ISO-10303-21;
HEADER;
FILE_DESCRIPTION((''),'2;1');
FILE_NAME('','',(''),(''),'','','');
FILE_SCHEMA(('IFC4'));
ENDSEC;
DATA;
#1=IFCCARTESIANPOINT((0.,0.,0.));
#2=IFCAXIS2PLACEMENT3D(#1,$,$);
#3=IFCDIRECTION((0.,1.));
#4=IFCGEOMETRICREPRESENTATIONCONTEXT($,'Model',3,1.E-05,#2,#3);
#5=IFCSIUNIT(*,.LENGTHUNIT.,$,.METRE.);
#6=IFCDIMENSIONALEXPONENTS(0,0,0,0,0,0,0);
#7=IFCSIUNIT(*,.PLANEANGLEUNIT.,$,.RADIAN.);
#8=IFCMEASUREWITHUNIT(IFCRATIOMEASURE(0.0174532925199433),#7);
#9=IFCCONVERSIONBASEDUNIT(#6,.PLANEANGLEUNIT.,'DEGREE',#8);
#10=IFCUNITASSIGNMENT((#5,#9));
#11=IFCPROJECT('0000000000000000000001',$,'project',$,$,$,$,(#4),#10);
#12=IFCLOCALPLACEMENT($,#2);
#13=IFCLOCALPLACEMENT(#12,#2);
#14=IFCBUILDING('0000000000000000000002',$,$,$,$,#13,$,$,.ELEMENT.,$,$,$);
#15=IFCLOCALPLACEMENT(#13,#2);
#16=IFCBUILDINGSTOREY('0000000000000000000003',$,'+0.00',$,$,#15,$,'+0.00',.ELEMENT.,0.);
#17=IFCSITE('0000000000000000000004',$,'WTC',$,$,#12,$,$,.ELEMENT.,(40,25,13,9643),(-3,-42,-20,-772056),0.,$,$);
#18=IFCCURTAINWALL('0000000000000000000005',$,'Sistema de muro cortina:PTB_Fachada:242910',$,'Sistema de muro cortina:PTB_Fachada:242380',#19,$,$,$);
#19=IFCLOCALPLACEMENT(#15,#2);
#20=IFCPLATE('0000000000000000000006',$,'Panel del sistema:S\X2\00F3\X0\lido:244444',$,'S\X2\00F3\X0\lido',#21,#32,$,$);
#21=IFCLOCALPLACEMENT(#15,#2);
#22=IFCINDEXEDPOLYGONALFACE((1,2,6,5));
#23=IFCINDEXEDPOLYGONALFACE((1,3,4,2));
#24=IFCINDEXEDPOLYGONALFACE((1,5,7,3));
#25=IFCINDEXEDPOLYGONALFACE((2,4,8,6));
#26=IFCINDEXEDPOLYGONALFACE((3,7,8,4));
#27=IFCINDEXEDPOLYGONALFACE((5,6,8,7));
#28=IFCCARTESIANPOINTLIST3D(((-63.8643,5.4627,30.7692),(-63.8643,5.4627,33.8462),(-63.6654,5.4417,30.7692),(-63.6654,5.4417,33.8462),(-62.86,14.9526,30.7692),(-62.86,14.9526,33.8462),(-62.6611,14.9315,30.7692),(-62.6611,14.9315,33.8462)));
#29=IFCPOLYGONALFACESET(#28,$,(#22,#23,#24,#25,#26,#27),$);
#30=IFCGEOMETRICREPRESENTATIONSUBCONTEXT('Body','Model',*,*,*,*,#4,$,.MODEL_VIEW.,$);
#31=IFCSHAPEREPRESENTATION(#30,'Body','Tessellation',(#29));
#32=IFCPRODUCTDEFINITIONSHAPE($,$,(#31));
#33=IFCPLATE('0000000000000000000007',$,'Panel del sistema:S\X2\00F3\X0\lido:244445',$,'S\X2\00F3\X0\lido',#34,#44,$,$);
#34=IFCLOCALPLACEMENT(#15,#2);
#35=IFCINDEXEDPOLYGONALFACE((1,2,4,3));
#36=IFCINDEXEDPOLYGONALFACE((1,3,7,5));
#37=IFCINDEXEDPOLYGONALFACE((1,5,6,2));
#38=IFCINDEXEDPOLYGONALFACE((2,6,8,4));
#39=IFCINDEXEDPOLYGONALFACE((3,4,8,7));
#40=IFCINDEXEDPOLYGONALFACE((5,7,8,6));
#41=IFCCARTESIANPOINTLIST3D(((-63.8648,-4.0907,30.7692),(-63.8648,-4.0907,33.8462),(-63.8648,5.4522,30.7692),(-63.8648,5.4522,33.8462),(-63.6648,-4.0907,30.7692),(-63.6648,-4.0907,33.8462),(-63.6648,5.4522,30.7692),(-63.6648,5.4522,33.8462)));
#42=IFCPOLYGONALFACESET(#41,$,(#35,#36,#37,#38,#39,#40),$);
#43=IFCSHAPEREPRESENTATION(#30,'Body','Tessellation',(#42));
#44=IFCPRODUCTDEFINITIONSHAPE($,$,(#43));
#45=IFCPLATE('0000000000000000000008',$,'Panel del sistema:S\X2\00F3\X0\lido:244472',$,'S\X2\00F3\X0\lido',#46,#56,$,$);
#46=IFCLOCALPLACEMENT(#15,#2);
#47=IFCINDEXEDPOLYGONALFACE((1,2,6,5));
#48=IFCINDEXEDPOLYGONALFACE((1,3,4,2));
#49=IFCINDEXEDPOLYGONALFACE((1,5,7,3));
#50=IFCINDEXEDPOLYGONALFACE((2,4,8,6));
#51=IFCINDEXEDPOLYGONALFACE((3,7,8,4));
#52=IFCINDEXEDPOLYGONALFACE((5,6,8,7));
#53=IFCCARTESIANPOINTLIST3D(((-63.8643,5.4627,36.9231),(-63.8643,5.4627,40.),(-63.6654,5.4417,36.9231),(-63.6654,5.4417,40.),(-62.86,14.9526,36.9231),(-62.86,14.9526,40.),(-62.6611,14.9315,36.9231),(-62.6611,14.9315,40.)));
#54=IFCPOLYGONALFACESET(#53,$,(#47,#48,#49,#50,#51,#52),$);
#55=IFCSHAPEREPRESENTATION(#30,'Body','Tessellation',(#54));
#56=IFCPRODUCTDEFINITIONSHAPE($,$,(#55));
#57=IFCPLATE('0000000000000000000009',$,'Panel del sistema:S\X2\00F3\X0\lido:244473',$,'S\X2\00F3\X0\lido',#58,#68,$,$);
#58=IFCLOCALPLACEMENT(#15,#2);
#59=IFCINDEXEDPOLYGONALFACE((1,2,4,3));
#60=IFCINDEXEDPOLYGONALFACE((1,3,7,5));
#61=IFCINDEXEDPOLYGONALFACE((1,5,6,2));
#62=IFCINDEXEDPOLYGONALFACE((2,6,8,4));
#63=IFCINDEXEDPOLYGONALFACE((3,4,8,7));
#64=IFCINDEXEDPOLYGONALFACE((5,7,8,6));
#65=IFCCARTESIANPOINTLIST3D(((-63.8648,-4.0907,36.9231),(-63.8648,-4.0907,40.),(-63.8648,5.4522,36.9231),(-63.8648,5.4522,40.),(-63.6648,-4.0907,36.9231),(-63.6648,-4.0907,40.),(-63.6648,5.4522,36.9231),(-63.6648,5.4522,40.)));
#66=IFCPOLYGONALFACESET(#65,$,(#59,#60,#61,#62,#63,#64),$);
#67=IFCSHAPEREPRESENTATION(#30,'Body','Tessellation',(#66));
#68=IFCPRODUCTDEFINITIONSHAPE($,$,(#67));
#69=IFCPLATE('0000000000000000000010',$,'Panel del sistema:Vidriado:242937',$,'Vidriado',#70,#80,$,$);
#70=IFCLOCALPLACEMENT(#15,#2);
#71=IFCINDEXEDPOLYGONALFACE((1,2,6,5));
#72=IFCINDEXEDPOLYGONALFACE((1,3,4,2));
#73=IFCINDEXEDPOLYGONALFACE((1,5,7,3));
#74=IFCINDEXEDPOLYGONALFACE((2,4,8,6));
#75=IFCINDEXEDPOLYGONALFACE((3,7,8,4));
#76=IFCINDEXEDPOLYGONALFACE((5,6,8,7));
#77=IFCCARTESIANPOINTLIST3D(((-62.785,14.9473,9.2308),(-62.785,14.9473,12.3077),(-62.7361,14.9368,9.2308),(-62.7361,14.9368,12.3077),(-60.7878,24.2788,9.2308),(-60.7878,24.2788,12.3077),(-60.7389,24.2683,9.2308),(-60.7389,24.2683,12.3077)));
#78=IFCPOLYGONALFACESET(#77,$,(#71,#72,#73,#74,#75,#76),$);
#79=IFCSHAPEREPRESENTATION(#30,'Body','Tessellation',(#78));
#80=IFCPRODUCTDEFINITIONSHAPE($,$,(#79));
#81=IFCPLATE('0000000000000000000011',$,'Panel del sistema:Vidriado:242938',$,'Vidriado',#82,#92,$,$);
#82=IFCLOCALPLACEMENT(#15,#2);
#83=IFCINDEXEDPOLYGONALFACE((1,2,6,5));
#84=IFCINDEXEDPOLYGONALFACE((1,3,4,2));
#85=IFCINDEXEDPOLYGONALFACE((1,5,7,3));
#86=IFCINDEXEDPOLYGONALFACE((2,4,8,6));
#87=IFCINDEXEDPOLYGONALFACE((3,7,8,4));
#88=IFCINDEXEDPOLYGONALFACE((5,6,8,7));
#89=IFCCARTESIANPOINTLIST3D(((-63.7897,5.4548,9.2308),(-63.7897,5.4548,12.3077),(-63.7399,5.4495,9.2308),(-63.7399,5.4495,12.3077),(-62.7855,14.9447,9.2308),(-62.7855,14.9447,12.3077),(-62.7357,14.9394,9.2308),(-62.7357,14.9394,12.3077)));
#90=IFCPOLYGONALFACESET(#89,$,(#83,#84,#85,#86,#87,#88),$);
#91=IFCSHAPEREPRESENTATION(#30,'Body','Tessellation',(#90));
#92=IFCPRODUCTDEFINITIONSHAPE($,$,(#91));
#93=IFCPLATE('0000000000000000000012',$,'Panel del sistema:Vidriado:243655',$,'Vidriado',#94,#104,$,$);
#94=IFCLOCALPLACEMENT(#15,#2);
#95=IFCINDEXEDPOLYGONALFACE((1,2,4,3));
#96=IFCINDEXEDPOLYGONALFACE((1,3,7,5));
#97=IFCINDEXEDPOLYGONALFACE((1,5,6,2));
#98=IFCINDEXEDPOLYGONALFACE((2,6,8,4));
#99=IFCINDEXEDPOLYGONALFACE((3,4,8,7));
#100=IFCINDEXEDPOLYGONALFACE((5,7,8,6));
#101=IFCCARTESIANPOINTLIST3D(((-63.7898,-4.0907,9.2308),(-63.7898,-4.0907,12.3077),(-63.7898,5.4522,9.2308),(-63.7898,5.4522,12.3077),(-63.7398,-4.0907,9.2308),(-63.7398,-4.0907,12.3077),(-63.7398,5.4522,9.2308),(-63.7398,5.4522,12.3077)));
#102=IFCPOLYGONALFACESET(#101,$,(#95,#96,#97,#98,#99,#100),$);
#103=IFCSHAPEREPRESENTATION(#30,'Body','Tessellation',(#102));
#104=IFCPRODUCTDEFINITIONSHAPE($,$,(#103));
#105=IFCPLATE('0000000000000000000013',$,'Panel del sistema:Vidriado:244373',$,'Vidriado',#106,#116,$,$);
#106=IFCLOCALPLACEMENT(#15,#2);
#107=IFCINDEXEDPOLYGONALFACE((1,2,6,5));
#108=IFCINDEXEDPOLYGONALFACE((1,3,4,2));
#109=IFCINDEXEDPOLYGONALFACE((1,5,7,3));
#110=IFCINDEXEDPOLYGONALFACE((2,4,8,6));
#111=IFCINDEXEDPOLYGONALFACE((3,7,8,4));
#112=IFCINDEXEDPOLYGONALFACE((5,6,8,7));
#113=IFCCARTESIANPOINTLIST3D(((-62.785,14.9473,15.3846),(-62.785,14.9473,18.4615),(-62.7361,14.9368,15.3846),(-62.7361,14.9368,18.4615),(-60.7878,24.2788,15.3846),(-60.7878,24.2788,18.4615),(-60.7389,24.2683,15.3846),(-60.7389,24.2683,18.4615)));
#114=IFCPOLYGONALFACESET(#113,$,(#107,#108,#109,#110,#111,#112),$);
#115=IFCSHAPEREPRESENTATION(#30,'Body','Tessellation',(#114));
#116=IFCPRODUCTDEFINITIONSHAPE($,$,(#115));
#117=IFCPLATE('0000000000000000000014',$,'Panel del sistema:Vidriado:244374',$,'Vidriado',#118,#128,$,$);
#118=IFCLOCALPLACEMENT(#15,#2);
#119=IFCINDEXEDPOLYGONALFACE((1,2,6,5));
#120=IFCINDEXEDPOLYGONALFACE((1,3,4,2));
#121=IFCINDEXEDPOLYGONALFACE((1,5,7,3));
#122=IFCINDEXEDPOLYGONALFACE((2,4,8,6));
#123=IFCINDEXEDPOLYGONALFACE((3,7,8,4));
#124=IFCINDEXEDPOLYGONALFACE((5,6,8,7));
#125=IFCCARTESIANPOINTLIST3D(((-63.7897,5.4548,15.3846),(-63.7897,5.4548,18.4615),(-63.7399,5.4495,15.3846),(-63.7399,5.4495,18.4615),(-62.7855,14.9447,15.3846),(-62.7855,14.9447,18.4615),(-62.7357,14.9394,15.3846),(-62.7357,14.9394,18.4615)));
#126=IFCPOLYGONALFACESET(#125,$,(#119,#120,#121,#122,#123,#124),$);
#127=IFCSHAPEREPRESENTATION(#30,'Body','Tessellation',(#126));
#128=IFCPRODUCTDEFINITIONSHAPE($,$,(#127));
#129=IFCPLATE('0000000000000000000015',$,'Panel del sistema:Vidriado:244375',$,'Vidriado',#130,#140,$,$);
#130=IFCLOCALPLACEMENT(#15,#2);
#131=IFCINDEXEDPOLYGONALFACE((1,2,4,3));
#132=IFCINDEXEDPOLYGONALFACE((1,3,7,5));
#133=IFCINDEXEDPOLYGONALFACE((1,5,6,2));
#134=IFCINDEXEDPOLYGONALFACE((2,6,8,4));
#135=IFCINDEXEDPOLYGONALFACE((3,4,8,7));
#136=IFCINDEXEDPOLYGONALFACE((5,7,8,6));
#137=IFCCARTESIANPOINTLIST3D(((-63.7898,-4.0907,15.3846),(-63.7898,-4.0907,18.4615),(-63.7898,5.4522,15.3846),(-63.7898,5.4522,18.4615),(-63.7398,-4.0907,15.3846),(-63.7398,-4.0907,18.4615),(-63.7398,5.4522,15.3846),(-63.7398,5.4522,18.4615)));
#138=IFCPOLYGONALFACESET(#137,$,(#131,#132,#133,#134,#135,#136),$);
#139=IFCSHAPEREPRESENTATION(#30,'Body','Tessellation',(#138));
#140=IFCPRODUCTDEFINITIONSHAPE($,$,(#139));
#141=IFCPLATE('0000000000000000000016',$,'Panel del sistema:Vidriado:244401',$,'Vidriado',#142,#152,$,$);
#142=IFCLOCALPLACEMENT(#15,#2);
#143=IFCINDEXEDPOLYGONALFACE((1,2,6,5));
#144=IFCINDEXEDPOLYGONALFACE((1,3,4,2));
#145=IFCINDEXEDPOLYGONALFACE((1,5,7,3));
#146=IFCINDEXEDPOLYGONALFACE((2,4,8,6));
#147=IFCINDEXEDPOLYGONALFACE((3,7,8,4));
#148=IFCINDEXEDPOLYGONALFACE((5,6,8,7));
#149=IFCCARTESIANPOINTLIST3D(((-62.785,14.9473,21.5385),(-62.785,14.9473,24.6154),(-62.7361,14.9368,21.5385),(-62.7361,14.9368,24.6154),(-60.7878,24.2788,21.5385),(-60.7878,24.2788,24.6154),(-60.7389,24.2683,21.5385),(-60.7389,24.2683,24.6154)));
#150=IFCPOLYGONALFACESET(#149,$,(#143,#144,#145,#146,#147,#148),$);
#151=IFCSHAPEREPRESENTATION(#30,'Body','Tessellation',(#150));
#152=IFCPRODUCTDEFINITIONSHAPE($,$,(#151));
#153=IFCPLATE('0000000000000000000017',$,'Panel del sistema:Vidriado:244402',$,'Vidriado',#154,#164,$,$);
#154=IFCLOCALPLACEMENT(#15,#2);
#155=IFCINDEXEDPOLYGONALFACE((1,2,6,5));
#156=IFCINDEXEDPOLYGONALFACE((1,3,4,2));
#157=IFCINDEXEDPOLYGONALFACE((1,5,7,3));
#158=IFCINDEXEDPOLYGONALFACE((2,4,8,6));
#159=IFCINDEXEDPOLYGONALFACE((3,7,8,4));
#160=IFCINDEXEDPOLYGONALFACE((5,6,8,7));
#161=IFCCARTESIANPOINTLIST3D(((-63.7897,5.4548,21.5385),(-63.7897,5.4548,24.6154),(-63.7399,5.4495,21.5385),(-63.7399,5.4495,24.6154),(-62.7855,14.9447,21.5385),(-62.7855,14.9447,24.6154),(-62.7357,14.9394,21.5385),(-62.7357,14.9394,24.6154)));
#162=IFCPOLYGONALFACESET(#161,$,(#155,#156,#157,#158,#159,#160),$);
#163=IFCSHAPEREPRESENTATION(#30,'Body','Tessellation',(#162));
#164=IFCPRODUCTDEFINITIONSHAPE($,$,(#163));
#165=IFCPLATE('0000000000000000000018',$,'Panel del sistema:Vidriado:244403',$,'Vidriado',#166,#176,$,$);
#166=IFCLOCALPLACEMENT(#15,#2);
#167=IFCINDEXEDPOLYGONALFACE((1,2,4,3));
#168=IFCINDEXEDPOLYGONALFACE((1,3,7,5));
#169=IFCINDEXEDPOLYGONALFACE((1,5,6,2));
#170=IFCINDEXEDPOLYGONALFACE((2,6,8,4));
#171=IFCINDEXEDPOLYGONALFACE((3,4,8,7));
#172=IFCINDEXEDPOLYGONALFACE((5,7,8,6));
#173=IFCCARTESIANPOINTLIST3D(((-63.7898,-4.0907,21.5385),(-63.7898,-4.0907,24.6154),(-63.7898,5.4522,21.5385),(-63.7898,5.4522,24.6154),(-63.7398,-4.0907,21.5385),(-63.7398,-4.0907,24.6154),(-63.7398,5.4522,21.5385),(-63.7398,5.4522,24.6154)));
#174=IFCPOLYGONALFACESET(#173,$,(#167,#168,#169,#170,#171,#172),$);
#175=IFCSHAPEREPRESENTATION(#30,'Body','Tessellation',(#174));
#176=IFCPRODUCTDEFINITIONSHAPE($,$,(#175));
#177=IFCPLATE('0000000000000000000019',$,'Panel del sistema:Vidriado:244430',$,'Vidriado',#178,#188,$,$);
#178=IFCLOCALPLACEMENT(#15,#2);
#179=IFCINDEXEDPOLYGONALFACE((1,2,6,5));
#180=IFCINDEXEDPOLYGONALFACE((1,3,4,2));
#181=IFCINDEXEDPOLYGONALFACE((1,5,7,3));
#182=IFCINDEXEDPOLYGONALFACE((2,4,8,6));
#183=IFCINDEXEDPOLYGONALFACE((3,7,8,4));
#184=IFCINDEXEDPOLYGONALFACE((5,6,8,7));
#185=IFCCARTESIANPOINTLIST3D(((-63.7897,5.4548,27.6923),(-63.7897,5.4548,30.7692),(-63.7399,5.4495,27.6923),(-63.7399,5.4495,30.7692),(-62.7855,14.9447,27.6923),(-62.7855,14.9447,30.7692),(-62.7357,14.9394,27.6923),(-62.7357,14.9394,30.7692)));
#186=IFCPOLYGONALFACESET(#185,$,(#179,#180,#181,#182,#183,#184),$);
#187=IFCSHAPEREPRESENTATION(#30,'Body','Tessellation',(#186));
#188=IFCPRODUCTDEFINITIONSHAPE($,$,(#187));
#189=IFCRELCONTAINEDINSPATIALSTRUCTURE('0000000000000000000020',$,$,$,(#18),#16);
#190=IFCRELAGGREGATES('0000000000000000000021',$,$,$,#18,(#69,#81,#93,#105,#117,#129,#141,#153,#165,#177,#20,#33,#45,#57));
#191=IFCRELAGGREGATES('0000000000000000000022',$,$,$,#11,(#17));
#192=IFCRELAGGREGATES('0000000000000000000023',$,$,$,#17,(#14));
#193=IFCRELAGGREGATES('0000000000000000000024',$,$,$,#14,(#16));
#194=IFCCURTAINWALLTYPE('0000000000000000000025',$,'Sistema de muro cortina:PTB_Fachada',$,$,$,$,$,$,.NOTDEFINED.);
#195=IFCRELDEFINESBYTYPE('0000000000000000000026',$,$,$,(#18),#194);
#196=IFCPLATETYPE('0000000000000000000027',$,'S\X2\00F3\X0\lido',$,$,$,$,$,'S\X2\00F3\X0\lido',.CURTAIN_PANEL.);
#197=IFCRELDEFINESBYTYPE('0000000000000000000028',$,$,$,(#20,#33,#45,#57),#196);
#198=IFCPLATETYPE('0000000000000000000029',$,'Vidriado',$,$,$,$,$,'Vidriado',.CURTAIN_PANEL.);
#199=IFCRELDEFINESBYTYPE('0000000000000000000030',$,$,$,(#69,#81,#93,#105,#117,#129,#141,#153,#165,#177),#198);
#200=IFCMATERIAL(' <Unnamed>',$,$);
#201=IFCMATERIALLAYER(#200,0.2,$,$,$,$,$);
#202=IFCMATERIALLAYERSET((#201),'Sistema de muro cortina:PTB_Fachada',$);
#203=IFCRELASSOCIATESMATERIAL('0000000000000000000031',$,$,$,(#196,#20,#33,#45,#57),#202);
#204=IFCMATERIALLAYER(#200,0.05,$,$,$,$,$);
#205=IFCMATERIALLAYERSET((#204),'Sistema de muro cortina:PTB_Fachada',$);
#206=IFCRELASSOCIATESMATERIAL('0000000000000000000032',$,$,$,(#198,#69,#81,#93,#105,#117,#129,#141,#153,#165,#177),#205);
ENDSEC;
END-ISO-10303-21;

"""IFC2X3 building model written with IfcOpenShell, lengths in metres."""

from ifc_helpers import new_model, entity, si_unit, converted_unit, direction, frame, frame_2d, origin, origin_2d_with_axis, place, context, subcontext, project, spatial, rectangle, extrude, source, transform, mapped, material, layer, layer_set, layer_usage, type_object, type_shapes, element, aggregate, save


model = new_model("IFC2X3")

# Units and contexts
model_context = context("Model", 3, precision=1e-05, world=origin(), true_north=direction((0.0, 1.0)))
body_context = subcontext(model_context, "Body", "Model", "MODEL_VIEW")
ifc_project = project(units=[si_unit("LENGTHUNIT", "METRE"), converted_unit("PLANEANGLEUNIT", "DEGREE", entity("IfcRatioMeasure", 0.0174532925199433), si_unit("PLANEANGLEUNIT", "RADIAN"), dimensions=[0, 0, 0, 0, 0, 0, 0])], contexts=[model_context])

# Site, building, storey
site_placement = place(None, origin())
site = spatial("IfcSite", under=ifc_project, at=site_placement, Name="WTC", CompositionType="ELEMENT", RefLatitude=(40, 25, 13, 9643), RefLongitude=(-3, -42, -20, -772056), RefElevation=0.0)
building_placement = place(site_placement, origin())
building = spatial("IfcBuilding", under=site, at=building_placement, CompositionType="ELEMENT")
storey_placement = place(building_placement, origin())
storey = spatial("IfcBuildingStorey", under=building, at=storey_placement, Name="+0.00", LongName="+0.00", CompositionType="ELEMENT", Elevation=0.0)

# Curtain wall, plates
curtain_wall_type = type_object("IfcCurtainWallType", Name="Sistema de muro cortina:PTB_Fachada", PredefinedType="NOTDEFINED")
curtain_wall_placement = place(storey_placement, origin())
curtain_wall = element("IfcCurtainWall", 1, at=curtain_wall_placement, inside=storey, type_object=curtain_wall_type, Name="Sistema de muro cortina:PTB_Fachada:242910", ObjectType="Sistema de muro cortina:PTB_Fachada:242380")
ifc_material_1 = material(Name=" <Unnamed>")
ifc_layer_1 = layer(ifc_material_1, 0.2)
ifc_layer_set_1 = layer_set([ifc_layer_1], Name="Sistema de muro cortina:PTB_Fachada")
plate_type_1 = type_object("IfcPlateType", Name="Sólido", ElementType="Sólido", PredefinedType="CURTAIN_PANEL", material=ifc_layer_set_1)
shared_shape_1 = source(origin(), body_context, "Body", "SweptSolid", [
    extrude(rectangle(XDim=0.2, YDim=9.5428, at=frame_2d((0.0, 0.0), x_axis=(1.0, 0.0))), frame((0.0, 0.0, 0.0), z_axis=(0.0, 0.0, 1.0), x_axis=(0.0, 1.0, 0.0)), (0.0, 0.0, 1.0), 3.0769),
])
type_shapes(plate_type_1, [shared_shape_1])
ifc_layer_usage_1 = layer_usage(ifc_layer_set_1, "AXIS3", "POSITIVE", 0.0)
plate_1_placement = place(curtain_wall_placement, frame((-63.2627, 10.1971, 30.7692), z_axis=(0.0, 0.0, 1.0), x_axis=(-0.105232, -0.994448, 0.0)))
plate_1 = element("IfcPlate", 2, at=plate_1_placement, type_object=plate_type_1, material=ifc_layer_usage_1, Name="Panel del sistema:Sólido:244444", ObjectType="Sólido", context=body_context, shape_type="MappedRepresentation", body=[
    mapped(shared_shape_1, transform((0.0, 0.0, 0.0), scale=1.0)),
])
ifc_layer_usage_2 = layer_usage(ifc_layer_set_1, "AXIS3", "POSITIVE", 0.0)
plate_2_placement = place(curtain_wall_placement, frame((-63.7648, 0.6808, 30.7692), z_axis=(0.0, 0.0, 1.0), x_axis=(0.0, -1.0, 0.0)))
plate_2 = element("IfcPlate", 3, at=plate_2_placement, type_object=plate_type_1, material=ifc_layer_usage_2, Name="Panel del sistema:Sólido:244445", ObjectType="Sólido", context=body_context, shape_type="MappedRepresentation", body=[
    mapped(shared_shape_1, transform((0.0, 0.0, 0.0), scale=1.0)),
])
ifc_layer_usage_3 = layer_usage(ifc_layer_set_1, "AXIS3", "POSITIVE", 0.0)
plate_3_placement = place(curtain_wall_placement, frame((-63.2627, 10.1971, 36.9231), z_axis=(0.0, 0.0, 1.0), x_axis=(-0.105232, -0.994448, 0.0)))
plate_3 = element("IfcPlate", 4, at=plate_3_placement, type_object=plate_type_1, material=ifc_layer_usage_3, Name="Panel del sistema:Sólido:244472", ObjectType="Sólido", context=body_context, shape_type="MappedRepresentation", body=[
    mapped(shared_shape_1, transform((0.0, 0.0, 0.0), scale=1.0)),
])
ifc_layer_usage_4 = layer_usage(ifc_layer_set_1, "AXIS3", "POSITIVE", 0.0)
plate_4_placement = place(curtain_wall_placement, frame((-63.7648, 0.6808, 36.9231), z_axis=(0.0, 0.0, 1.0), x_axis=(0.0, -1.0, 0.0)))
plate_4 = element("IfcPlate", 5, at=plate_4_placement, type_object=plate_type_1, material=ifc_layer_usage_4, Name="Panel del sistema:Sólido:244473", ObjectType="Sólido", context=body_context, shape_type="MappedRepresentation", body=[
    mapped(shared_shape_1, transform((0.0, 0.0, 0.0), scale=1.0)),
])
ifc_layer_2 = layer(ifc_material_1, 0.05)
ifc_layer_set_2 = layer_set([ifc_layer_2], Name="Sistema de muro cortina:PTB_Fachada")
ifc_layer_usage_5 = layer_usage(ifc_layer_set_2, "AXIS3", "POSITIVE", 0.0)
plate_type_2 = type_object("IfcPlateType", Name="Vidriado", ElementType="Vidriado", PredefinedType="CURTAIN_PANEL", material=ifc_layer_set_2)
shared_shape_2 = source(origin(), body_context, "Body", "SweptSolid", [
    extrude(rectangle(XDim=0.05, YDim=9.5428, at=origin_2d_with_axis()), frame((0.0, 0.0, 0.0), z_axis=(0.0, 0.0, 1.0), x_axis=(0.0, 1.0, 0.0)), (0.0, 0.0, 1.0), 3.0769),
])
type_shapes(plate_type_2, [shared_shape_2])
plate_5_placement = place(curtain_wall_placement, frame((-61.762, 19.6078, 9.2308), z_axis=(0.0, 0.0, 1.0), x_axis=(-0.209296, -0.977852, 0.0)))
plate_5 = element("IfcPlate", 6, at=plate_5_placement, type_object=plate_type_2, material=ifc_layer_usage_5, Name="Panel del sistema:Vidriado:242937", ObjectType="Vidriado", context=body_context, shape_type="MappedRepresentation", body=[
    mapped(shared_shape_2, transform((0.0, 0.0, 0.0), scale=1.0)),
])
ifc_layer_usage_6 = layer_usage(ifc_layer_set_2, "AXIS3", "POSITIVE", 0.0)
plate_6_placement = place(curtain_wall_placement, frame((-63.2627, 10.1971, 9.2308), z_axis=(0.0, 0.0, 1.0), x_axis=(-0.105232, -0.994448, 0.0)))
plate_6 = element("IfcPlate", 7, at=plate_6_placement, type_object=plate_type_2, material=ifc_layer_usage_6, Name="Panel del sistema:Vidriado:242938", ObjectType="Vidriado", context=body_context, shape_type="MappedRepresentation", body=[
    mapped(shared_shape_2, transform((0.0, 0.0, 0.0), scale=1.0)),
])
ifc_layer_usage_7 = layer_usage(ifc_layer_set_2, "AXIS3", "POSITIVE", 0.0)
plate_7_placement = place(curtain_wall_placement, frame((-63.7648, 0.6808, 9.2308), z_axis=(0.0, 0.0, 1.0), x_axis=(0.0, -1.0, 0.0)))
plate_7 = element("IfcPlate", 8, at=plate_7_placement, type_object=plate_type_2, material=ifc_layer_usage_7, Name="Panel del sistema:Vidriado:243655", ObjectType="Vidriado", context=body_context, shape_type="MappedRepresentation", body=[
    mapped(shared_shape_2, transform((0.0, 0.0, 0.0), scale=1.0)),
])
ifc_layer_usage_8 = layer_usage(ifc_layer_set_2, "AXIS3", "POSITIVE", 0.0)
plate_8_placement = place(curtain_wall_placement, frame((-61.762, 19.6078, 15.3846), z_axis=(0.0, 0.0, 1.0), x_axis=(-0.209296, -0.977852, 0.0)))
plate_8 = element("IfcPlate", 9, at=plate_8_placement, type_object=plate_type_2, material=ifc_layer_usage_8, Name="Panel del sistema:Vidriado:244373", ObjectType="Vidriado", context=body_context, shape_type="MappedRepresentation", body=[
    mapped(shared_shape_2, transform((0.0, 0.0, 0.0), scale=1.0)),
])
ifc_layer_usage_9 = layer_usage(ifc_layer_set_2, "AXIS3", "POSITIVE", 0.0)
plate_9_placement = place(curtain_wall_placement, frame((-63.2627, 10.1971, 15.3846), z_axis=(0.0, 0.0, 1.0), x_axis=(-0.105232, -0.994448, 0.0)))
plate_9 = element("IfcPlate", 10, at=plate_9_placement, type_object=plate_type_2, material=ifc_layer_usage_9, Name="Panel del sistema:Vidriado:244374", ObjectType="Vidriado", context=body_context, shape_type="MappedRepresentation", body=[
    mapped(shared_shape_2, transform((0.0, 0.0, 0.0), scale=1.0)),
])
ifc_layer_usage_10 = layer_usage(ifc_layer_set_2, "AXIS3", "POSITIVE", 0.0)
plate_10_placement = place(curtain_wall_placement, frame((-63.7648, 0.6808, 15.3846), z_axis=(0.0, 0.0, 1.0), x_axis=(0.0, -1.0, 0.0)))
plate_10 = element("IfcPlate", 11, at=plate_10_placement, type_object=plate_type_2, material=ifc_layer_usage_10, Name="Panel del sistema:Vidriado:244375", ObjectType="Vidriado", context=body_context, shape_type="MappedRepresentation", body=[
    mapped(shared_shape_2, transform((0.0, 0.0, 0.0), scale=1.0)),
])
ifc_layer_usage_11 = layer_usage(ifc_layer_set_2, "AXIS3", "POSITIVE", 0.0)
plate_11_placement = place(curtain_wall_placement, frame((-61.762, 19.6078, 21.5385), z_axis=(0.0, 0.0, 1.0), x_axis=(-0.209296, -0.977852, 0.0)))
plate_11 = element("IfcPlate", 12, at=plate_11_placement, type_object=plate_type_2, material=ifc_layer_usage_11, Name="Panel del sistema:Vidriado:244401", ObjectType="Vidriado", context=body_context, shape_type="MappedRepresentation", body=[
    mapped(shared_shape_2, transform((0.0, 0.0, 0.0), scale=1.0)),
])
ifc_layer_usage_12 = layer_usage(ifc_layer_set_2, "AXIS3", "POSITIVE", 0.0)
plate_12_placement = place(curtain_wall_placement, frame((-63.2627, 10.1971, 21.5385), z_axis=(0.0, 0.0, 1.0), x_axis=(-0.105232, -0.994448, 0.0)))
plate_12 = element("IfcPlate", 13, at=plate_12_placement, type_object=plate_type_2, material=ifc_layer_usage_12, Name="Panel del sistema:Vidriado:244402", ObjectType="Vidriado", context=body_context, shape_type="MappedRepresentation", body=[
    mapped(shared_shape_2, transform((0.0, 0.0, 0.0), scale=1.0)),
])
ifc_layer_usage_13 = layer_usage(ifc_layer_set_2, "AXIS3", "POSITIVE", 0.0)
plate_13_placement = place(curtain_wall_placement, frame((-63.7648, 0.6808, 21.5385), z_axis=(0.0, 0.0, 1.0), x_axis=(0.0, -1.0, 0.0)))
plate_13 = element("IfcPlate", 14, at=plate_13_placement, type_object=plate_type_2, material=ifc_layer_usage_13, Name="Panel del sistema:Vidriado:244403", ObjectType="Vidriado", context=body_context, shape_type="MappedRepresentation", body=[
    mapped(shared_shape_2, transform((0.0, 0.0, 0.0), scale=1.0)),
])
ifc_layer_usage_14 = layer_usage(ifc_layer_set_2, "AXIS3", "POSITIVE", 0.0)
plate_14_placement = place(curtain_wall_placement, frame((-63.2627, 10.1971, 27.6923), z_axis=(0.0, 0.0, 1.0), x_axis=(-0.105232, -0.994448, 0.0)))
plate_14 = element("IfcPlate", 15, at=plate_14_placement, type_object=plate_type_2, material=ifc_layer_usage_14, Name="Panel del sistema:Vidriado:244430", ObjectType="Vidriado", context=body_context, shape_type="MappedRepresentation", body=[
    mapped(shared_shape_2, transform((0.0, 0.0, 0.0), scale=1.0)),
])
aggregate(curtain_wall, [plate_5, plate_6, plate_7, plate_8, plate_9, plate_10, plate_11, plate_12, plate_13, plate_14, plate_1, plate_2, plate_3, plate_4])

save(model, "model.ifc")
